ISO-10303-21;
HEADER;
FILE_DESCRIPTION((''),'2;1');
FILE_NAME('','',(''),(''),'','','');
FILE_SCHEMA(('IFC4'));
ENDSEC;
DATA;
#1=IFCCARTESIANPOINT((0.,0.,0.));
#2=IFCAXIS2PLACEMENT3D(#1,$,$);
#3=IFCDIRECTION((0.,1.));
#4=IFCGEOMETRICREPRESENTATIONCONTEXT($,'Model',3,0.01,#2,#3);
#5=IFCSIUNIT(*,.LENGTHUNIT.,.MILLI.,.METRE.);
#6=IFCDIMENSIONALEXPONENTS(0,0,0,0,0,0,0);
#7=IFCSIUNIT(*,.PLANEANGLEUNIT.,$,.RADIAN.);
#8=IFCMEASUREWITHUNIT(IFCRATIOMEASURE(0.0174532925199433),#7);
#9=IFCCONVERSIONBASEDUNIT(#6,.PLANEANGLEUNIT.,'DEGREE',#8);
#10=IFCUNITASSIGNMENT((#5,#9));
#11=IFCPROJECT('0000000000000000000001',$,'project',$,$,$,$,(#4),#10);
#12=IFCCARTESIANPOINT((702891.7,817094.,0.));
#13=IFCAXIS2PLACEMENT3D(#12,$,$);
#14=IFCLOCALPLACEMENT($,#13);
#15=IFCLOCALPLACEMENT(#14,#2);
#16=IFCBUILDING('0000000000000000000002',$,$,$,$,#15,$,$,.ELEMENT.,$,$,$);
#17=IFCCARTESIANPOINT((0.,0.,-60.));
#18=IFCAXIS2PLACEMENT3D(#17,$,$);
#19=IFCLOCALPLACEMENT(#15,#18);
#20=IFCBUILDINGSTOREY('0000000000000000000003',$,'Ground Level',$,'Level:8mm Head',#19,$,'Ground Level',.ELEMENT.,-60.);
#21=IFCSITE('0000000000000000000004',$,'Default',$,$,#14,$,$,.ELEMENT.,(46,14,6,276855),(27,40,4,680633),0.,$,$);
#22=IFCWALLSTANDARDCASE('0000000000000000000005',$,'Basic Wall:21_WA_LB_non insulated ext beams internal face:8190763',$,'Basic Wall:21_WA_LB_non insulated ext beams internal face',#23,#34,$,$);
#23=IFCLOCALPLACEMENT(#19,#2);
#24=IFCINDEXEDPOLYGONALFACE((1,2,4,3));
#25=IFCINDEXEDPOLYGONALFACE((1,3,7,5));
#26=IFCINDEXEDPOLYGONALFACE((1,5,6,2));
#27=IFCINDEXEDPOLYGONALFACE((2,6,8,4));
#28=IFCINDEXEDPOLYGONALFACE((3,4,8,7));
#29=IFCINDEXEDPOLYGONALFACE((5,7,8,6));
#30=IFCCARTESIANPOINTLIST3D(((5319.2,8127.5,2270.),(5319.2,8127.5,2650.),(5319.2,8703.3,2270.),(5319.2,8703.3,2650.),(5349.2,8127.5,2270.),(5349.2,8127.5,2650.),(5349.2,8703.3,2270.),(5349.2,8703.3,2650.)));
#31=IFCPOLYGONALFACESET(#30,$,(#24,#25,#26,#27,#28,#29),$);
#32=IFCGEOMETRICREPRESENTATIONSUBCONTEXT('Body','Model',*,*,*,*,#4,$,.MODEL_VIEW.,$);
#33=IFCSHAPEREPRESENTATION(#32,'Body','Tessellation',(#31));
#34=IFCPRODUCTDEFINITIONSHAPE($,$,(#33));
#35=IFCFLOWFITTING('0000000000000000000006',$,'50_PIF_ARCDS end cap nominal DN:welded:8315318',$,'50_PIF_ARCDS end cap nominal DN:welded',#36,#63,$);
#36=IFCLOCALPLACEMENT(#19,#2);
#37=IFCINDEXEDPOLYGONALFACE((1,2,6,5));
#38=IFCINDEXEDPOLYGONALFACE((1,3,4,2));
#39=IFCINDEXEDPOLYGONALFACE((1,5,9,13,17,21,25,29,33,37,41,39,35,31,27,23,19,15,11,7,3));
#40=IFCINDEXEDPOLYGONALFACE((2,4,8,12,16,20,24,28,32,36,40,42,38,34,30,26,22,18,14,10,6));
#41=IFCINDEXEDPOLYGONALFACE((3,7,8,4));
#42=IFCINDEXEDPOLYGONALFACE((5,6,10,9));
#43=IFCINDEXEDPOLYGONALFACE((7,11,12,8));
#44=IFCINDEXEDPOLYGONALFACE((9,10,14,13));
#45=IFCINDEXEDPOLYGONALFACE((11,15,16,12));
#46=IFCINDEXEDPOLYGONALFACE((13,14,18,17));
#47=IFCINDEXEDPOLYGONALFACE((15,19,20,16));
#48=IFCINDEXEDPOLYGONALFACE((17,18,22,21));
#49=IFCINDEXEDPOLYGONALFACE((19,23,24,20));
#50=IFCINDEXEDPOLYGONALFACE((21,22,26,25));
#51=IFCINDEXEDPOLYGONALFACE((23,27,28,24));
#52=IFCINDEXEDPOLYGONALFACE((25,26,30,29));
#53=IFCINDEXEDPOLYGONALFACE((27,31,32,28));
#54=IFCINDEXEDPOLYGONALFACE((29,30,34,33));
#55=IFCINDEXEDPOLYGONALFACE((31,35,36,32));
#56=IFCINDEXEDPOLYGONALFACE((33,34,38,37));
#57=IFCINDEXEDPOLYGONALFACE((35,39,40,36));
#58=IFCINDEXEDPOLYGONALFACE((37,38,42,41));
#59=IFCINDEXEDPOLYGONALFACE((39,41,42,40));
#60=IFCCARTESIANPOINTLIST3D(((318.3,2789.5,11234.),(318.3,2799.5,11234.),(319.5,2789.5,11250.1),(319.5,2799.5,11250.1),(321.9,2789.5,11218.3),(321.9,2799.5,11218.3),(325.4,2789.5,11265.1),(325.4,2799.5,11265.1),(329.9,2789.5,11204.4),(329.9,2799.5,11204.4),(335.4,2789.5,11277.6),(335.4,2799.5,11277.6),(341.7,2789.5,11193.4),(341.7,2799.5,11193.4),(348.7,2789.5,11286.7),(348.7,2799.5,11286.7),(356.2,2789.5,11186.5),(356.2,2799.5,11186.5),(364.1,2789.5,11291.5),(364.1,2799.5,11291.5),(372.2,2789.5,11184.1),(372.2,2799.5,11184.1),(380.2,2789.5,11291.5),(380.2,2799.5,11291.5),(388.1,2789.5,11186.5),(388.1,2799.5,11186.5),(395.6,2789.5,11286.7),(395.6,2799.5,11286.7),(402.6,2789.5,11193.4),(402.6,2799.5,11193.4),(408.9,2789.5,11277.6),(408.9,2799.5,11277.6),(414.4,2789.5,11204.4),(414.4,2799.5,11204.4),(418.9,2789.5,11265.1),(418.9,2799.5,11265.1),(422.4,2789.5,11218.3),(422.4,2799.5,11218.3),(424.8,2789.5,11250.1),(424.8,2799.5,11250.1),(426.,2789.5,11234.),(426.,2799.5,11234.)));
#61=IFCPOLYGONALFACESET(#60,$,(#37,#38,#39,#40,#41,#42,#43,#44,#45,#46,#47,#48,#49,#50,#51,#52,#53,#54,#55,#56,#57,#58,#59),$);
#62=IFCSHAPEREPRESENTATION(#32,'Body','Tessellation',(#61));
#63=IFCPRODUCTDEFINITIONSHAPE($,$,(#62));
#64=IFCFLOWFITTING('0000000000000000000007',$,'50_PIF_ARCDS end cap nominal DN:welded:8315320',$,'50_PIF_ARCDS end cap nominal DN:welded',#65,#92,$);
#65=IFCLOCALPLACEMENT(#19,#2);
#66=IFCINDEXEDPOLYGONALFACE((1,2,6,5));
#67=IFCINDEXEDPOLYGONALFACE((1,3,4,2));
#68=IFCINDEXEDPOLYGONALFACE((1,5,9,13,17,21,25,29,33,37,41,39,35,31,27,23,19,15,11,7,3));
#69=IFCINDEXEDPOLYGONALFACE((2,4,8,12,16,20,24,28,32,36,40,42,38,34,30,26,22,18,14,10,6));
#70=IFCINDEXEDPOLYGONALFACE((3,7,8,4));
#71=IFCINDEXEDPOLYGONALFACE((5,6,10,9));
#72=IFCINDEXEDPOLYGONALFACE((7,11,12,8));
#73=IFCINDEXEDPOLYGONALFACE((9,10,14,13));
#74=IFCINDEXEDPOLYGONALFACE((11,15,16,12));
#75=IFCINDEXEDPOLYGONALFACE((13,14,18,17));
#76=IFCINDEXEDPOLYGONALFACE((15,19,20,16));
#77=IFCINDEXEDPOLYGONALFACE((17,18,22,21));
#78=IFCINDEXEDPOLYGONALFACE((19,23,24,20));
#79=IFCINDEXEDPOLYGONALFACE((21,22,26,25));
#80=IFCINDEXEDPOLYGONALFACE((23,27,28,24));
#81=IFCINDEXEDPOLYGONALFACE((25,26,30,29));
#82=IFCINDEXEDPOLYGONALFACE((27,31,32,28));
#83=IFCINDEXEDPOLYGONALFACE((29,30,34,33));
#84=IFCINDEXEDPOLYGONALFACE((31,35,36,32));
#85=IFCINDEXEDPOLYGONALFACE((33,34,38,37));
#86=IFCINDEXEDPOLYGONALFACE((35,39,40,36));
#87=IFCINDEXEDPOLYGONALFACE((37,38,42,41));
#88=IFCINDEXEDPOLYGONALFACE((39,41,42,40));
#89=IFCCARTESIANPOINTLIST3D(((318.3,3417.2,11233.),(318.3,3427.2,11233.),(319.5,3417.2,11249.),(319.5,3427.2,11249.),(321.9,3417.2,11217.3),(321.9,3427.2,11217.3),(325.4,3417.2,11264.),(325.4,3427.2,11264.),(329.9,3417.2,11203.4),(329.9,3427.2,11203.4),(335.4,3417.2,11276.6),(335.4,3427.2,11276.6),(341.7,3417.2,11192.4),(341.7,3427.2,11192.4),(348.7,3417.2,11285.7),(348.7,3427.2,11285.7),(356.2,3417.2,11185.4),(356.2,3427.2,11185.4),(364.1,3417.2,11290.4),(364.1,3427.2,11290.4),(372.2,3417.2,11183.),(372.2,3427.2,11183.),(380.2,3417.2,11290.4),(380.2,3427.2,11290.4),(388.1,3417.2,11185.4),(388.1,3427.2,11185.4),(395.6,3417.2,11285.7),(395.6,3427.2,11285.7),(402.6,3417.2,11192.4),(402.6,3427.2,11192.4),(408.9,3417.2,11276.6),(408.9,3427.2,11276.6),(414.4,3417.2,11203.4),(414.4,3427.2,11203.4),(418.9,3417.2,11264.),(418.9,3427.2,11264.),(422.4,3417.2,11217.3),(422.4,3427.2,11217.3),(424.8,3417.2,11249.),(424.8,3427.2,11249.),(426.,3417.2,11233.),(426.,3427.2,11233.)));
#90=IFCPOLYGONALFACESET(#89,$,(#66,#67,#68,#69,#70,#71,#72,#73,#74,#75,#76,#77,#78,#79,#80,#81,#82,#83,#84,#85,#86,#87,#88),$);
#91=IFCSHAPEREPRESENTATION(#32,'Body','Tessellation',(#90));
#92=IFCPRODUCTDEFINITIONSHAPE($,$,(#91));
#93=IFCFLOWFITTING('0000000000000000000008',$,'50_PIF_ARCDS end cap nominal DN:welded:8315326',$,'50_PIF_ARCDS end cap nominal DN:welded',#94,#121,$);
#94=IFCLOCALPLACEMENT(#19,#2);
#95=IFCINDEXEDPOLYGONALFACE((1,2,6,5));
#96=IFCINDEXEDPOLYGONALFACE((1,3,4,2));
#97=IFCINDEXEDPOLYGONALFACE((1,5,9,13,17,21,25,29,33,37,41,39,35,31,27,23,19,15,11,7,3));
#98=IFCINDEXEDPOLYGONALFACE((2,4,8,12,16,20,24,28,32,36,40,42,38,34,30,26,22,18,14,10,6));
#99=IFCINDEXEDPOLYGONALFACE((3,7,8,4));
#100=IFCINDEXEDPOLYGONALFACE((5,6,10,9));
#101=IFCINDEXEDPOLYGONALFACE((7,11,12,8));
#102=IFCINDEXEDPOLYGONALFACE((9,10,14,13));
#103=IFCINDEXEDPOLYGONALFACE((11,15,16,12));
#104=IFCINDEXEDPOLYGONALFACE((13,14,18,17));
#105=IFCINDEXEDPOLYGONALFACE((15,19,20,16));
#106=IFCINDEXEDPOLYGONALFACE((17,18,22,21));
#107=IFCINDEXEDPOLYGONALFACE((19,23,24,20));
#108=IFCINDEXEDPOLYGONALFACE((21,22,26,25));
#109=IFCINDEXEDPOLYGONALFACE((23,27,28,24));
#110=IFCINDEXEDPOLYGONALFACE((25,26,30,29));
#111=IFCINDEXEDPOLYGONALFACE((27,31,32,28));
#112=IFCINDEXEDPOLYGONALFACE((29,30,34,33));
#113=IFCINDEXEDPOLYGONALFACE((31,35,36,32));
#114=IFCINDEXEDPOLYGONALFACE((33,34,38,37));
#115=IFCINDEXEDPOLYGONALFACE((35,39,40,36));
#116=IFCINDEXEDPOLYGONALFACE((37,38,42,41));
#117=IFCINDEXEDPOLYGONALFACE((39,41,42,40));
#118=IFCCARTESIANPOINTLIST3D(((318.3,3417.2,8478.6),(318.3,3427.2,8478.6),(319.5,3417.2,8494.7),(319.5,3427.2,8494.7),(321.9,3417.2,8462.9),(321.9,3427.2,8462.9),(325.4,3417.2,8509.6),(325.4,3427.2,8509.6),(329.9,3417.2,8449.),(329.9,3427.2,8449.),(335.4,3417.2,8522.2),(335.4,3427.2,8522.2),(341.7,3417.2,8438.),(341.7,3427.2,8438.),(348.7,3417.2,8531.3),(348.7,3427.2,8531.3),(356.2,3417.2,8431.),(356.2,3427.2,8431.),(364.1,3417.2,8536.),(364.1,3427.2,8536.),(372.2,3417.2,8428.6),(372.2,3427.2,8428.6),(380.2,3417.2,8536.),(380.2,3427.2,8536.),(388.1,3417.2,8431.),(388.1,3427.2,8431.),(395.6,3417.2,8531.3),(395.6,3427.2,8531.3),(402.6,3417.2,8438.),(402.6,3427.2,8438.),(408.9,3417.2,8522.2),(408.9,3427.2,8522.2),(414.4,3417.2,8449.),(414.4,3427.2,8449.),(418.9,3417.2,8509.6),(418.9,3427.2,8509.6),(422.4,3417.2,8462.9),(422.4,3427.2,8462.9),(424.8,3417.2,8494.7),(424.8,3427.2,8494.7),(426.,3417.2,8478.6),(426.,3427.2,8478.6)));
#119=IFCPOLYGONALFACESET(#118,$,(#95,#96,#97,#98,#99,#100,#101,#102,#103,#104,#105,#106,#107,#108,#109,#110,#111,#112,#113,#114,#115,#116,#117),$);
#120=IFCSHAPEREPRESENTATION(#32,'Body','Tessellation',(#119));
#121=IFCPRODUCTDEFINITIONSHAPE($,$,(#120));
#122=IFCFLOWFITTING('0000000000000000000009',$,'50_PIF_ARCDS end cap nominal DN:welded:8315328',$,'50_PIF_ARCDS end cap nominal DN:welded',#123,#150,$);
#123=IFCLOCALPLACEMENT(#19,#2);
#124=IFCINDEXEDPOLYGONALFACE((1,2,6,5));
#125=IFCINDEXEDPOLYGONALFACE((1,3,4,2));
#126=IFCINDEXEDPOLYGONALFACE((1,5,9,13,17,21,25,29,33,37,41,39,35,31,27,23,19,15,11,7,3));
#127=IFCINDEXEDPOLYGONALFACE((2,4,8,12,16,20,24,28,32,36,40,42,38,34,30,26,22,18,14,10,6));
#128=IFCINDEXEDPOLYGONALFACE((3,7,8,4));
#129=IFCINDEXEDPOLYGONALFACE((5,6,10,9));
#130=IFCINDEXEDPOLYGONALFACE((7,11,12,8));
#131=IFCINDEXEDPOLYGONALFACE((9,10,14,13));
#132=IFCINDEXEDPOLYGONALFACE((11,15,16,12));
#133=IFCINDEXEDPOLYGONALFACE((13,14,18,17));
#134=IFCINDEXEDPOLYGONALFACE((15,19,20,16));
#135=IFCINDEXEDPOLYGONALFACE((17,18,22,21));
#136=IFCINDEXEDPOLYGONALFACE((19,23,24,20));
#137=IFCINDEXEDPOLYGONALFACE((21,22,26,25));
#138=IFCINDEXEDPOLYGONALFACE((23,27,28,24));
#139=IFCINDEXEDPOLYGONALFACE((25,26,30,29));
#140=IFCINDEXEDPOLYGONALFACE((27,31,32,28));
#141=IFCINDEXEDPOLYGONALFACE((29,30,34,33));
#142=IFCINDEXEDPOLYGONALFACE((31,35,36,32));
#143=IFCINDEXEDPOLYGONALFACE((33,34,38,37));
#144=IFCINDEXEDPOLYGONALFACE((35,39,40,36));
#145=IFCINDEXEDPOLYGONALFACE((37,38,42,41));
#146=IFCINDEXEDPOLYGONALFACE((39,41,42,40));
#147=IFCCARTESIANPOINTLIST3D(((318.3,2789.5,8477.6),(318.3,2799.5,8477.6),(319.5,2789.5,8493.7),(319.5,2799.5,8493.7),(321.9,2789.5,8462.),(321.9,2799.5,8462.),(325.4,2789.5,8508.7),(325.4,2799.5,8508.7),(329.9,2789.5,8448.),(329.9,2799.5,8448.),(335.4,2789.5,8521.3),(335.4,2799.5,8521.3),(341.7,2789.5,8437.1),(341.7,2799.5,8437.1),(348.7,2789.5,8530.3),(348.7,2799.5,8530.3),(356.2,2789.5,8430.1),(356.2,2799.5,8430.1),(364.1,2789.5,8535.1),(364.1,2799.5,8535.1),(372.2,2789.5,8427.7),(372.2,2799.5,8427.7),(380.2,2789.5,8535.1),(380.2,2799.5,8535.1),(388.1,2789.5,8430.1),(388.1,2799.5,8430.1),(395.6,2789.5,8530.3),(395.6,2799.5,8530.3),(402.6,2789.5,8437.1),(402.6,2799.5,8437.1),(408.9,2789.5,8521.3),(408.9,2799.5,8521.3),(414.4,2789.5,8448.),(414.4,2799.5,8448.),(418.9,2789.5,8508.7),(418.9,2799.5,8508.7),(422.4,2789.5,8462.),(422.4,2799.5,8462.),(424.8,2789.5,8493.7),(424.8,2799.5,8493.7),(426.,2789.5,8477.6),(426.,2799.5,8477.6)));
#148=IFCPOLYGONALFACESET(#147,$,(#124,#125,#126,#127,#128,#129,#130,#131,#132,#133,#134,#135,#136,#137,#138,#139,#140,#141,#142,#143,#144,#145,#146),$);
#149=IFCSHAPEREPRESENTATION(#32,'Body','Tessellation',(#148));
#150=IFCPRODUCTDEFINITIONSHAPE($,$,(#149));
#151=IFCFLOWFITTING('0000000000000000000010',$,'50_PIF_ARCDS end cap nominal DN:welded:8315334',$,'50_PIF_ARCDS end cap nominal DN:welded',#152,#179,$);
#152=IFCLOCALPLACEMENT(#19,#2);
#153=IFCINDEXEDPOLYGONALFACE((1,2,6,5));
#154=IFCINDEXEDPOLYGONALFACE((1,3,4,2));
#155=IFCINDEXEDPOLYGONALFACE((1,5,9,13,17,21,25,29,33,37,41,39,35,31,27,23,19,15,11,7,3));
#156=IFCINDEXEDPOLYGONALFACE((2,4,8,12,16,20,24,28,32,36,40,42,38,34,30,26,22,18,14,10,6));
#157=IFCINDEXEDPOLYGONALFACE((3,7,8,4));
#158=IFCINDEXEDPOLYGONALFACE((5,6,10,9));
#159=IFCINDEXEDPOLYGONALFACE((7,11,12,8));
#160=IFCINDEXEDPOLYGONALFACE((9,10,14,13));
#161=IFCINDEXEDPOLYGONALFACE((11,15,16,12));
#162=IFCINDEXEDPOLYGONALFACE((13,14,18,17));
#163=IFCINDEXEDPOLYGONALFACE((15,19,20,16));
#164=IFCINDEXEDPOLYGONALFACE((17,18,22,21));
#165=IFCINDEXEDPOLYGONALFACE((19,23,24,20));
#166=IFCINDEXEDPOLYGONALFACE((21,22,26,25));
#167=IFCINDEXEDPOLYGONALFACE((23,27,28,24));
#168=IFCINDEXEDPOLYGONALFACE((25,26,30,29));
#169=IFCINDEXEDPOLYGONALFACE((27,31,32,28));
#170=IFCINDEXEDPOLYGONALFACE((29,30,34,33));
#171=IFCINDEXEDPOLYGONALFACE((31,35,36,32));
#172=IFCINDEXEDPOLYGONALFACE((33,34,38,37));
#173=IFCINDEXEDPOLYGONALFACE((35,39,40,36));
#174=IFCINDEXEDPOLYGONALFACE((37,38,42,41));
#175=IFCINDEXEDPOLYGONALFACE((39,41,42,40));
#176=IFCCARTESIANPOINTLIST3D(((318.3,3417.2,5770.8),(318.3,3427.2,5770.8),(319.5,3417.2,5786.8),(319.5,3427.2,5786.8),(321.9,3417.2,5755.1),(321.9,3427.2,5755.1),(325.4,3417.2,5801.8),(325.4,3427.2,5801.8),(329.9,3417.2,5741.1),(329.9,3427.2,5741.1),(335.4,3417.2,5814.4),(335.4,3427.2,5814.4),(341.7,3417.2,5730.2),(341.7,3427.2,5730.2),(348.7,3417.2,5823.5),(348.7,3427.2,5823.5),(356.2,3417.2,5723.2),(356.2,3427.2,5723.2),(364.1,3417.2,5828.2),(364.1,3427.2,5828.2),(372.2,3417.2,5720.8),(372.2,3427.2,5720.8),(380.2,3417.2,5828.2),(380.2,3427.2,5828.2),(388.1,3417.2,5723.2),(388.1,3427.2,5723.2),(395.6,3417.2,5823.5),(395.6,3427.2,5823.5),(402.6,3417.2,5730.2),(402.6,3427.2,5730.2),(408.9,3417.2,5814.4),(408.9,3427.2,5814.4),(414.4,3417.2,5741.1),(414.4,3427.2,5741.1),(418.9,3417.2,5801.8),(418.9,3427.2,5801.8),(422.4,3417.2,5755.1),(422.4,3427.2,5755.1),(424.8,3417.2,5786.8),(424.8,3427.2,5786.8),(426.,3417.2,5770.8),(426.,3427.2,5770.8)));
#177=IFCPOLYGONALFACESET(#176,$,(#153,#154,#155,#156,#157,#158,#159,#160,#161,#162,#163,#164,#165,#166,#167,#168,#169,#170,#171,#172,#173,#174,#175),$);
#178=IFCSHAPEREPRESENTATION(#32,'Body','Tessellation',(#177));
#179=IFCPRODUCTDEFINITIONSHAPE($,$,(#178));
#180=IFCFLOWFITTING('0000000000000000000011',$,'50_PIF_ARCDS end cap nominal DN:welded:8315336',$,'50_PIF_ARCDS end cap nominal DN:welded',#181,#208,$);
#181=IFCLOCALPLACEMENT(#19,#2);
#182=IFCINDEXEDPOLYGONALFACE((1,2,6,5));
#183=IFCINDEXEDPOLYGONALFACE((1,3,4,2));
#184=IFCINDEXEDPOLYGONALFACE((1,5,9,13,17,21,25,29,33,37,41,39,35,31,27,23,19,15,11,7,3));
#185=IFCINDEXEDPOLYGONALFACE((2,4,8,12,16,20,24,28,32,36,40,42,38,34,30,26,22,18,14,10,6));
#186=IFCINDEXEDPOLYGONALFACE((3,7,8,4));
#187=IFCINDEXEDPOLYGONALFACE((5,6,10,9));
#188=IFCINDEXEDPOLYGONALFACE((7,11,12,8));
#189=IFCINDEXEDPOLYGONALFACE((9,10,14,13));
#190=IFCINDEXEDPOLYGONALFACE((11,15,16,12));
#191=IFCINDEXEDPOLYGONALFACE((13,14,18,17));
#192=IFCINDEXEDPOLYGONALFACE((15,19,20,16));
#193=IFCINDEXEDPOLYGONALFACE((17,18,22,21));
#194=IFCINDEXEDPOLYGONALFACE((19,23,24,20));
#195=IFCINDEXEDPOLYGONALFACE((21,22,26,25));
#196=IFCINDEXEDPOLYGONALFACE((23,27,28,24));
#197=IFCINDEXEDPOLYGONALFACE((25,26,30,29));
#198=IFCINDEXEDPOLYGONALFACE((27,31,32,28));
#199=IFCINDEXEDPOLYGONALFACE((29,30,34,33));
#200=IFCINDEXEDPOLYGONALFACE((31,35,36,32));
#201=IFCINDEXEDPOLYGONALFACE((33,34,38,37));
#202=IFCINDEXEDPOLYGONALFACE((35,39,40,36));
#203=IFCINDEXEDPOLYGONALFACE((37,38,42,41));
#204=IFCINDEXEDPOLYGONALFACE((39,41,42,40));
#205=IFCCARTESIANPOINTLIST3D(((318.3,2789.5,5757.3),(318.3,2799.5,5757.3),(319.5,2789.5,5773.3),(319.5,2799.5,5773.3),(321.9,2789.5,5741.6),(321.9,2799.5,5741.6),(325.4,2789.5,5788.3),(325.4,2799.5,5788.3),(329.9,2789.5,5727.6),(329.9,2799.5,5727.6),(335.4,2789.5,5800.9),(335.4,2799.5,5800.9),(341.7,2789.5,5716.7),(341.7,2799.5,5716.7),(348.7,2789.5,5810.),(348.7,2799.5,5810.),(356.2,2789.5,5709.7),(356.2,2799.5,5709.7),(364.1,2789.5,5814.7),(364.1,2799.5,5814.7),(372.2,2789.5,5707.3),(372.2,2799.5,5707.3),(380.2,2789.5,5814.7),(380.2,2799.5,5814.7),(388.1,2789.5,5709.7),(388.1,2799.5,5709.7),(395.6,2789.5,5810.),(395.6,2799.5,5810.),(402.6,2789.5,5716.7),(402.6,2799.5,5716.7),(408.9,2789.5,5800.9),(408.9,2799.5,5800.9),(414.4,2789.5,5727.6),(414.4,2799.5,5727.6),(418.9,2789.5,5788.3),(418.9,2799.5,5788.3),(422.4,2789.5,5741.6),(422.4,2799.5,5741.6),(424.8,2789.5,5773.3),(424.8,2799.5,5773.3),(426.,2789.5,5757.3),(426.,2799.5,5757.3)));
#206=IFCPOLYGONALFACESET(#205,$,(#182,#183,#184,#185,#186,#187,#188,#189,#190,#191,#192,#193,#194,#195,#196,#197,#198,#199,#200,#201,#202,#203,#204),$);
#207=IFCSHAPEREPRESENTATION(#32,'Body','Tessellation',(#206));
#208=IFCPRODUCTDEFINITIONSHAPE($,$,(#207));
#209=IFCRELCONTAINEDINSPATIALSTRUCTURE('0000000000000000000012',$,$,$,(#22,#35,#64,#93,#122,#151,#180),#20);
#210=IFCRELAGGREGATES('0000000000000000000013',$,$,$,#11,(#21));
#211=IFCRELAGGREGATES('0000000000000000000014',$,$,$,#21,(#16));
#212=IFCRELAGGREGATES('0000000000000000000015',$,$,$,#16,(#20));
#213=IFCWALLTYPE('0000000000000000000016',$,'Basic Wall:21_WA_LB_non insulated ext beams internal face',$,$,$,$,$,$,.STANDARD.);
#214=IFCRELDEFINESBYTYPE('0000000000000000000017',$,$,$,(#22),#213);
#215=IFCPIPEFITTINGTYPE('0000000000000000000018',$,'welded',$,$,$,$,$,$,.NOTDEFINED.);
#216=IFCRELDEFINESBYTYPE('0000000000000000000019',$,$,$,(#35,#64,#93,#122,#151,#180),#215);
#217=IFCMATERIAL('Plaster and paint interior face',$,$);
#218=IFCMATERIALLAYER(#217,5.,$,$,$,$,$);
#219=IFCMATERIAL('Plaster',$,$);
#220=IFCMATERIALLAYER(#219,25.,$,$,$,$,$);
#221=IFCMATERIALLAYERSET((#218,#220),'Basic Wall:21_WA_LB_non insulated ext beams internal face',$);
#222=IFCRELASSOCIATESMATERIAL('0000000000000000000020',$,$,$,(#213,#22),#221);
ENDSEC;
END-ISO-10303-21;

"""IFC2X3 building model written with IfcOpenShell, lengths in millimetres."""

from ifc_helpers import new_model, entity, si_unit, converted_unit, direction, frame, frame_2d, origin, place, context, subcontext, project, spatial, rectangle, circle, extrude, source, transform, mapped, material, layer, layer_set, layer_usage, type_object, type_shapes, element, save


model = new_model("IFC2X3")

# Units and contexts
model_context = context("Model", 3, precision=0.01, world=origin(), true_north=direction((0.0, 1.0)))
body_context = subcontext(model_context, "Body", "Model", "MODEL_VIEW")
ifc_project = project(units=[si_unit("LENGTHUNIT", "METRE", prefix="MILLI"), converted_unit("PLANEANGLEUNIT", "DEGREE", entity("IfcRatioMeasure", 0.0174532925199433), si_unit("PLANEANGLEUNIT", "RADIAN"), dimensions=[0, 0, 0, 0, 0, 0, 0])], contexts=[model_context])

# Site, building, storey
site_placement = place(None, frame((702891.7, 817094.0, 0.0)))
site = spatial("IfcSite", under=ifc_project, at=site_placement, Name="Default", CompositionType="ELEMENT", RefLatitude=(46, 14, 6, 276855), RefLongitude=(27, 40, 4, 680633), RefElevation=0.0)
building_placement = place(site_placement, origin())
building = spatial("IfcBuilding", under=site, at=building_placement, CompositionType="ELEMENT")
storey_placement = place(building_placement, frame((0.0, 0.0, -60.0)))
storey = spatial("IfcBuildingStorey", under=building, at=storey_placement, Name="Ground Level", ObjectType="Level:8mm Head", LongName="Ground Level", CompositionType="ELEMENT", Elevation=-60.0)

# Wall
ifc_material_1 = material(Name="Plaster")
ifc_material_2 = material(Name="Plaster and paint interior face")
ifc_layer_1 = layer(ifc_material_2, 5.0)
ifc_layer_2 = layer(ifc_material_1, 25.0)
ifc_layer_set_1 = layer_set([ifc_layer_1, ifc_layer_2], Name="Basic Wall:21_WA_LB_non insulated ext beams internal face")
wall_type_1 = type_object("IfcWallType", Name="Basic Wall:21_WA_LB_non insulated ext beams internal face", PredefinedType="STANDARD", material=ifc_layer_set_1)
ifc_layer_usage_1 = layer_usage(ifc_layer_set_1, "AXIS2", "NEGATIVE", 15.0)
wall_1_placement = place(storey_placement, frame((5334.2, 8127.5, 2270.0), z_axis=(0.0, 0.0, 1.0), x_axis=(0.0, 1.0, 0.0)))
element("IfcWallStandardCase", 1, at=wall_1_placement, inside=storey, type_object=wall_type_1, material=ifc_layer_usage_1, Name="Basic Wall:21_WA_LB_non insulated ext beams internal face:8190763", ObjectType="Basic Wall:21_WA_LB_non insulated ext beams internal face", context=body_context, shape_type="SweptSolid", body=[
    extrude(rectangle(XDim=575.8, YDim=30.0, at=frame_2d((287.9, 0.0), x_axis=(-1.0, 0.0))), origin(), (0.0, 0.0, 1.0), 380.0),
])

# Flow fittings
pipe_fitting_type = type_object("IfcPipeFittingType", Name="welded", PredefinedType="NOTDEFINED")
shared_shape_1 = source(origin(), body_context, "Body", "SweptSolid", [
    extrude(circle(Radius=54.0, at=frame_2d((0.0, 0.0), x_axis=(1.0, 0.0))), frame((0.0, 0.0, 0.0), z_axis=(1.0, 0.0, 0.0), x_axis=(0.0, 1.0, 0.0)), (0.0, 0.0, 1.0), 10.0),
])
type_shapes(pipe_fitting_type, [shared_shape_1])
for number, where, z_axis, x_axis, name in (
    (2, (372.2, 2799.5, 11238.1), (1.0, 0.0, 0.0), (0.0, -1.0, 0.0), "50_PIF_ARCDS end cap nominal DN:welded:8315318"),
    (3, (372.2, 3417.2, 11237.0), (-1.0, 0.0, 0.0), (0.0, 1.0, 0.0), "50_PIF_ARCDS end cap nominal DN:welded:8315320"),
    (4, (372.2, 3417.2, 8482.6), (-1.0, 0.0, 0.0), (0.0, 1.0, 0.0), "50_PIF_ARCDS end cap nominal DN:welded:8315326"),
    (5, (372.2, 2799.5, 8481.7), (1.0, 0.0, 0.0), (0.0, -1.0, 0.0), "50_PIF_ARCDS end cap nominal DN:welded:8315328"),
    (6, (372.2, 3417.2, 5774.8), (-1.0, 0.0, 0.0), (0.0, 1.0, 0.0), "50_PIF_ARCDS end cap nominal DN:welded:8315334"),
    (7, (372.2, 2799.5, 5761.3), (1.0, 0.0, 0.0), (0.0, -1.0, 0.0), "50_PIF_ARCDS end cap nominal DN:welded:8315336"),
):
    element("IfcFlowFitting", number, at=place(storey_placement, frame(where, z_axis=z_axis, x_axis=x_axis)), inside=storey, type_object=pipe_fitting_type, Name=name, ObjectType="50_PIF_ARCDS end cap nominal DN:welded", context=body_context, shape_type="MappedRepresentation", body=[
        mapped(shared_shape_1, transform((0.0, 0.0, 0.0), scale=1.0)),
    ])

save(model, "model.ifc")
